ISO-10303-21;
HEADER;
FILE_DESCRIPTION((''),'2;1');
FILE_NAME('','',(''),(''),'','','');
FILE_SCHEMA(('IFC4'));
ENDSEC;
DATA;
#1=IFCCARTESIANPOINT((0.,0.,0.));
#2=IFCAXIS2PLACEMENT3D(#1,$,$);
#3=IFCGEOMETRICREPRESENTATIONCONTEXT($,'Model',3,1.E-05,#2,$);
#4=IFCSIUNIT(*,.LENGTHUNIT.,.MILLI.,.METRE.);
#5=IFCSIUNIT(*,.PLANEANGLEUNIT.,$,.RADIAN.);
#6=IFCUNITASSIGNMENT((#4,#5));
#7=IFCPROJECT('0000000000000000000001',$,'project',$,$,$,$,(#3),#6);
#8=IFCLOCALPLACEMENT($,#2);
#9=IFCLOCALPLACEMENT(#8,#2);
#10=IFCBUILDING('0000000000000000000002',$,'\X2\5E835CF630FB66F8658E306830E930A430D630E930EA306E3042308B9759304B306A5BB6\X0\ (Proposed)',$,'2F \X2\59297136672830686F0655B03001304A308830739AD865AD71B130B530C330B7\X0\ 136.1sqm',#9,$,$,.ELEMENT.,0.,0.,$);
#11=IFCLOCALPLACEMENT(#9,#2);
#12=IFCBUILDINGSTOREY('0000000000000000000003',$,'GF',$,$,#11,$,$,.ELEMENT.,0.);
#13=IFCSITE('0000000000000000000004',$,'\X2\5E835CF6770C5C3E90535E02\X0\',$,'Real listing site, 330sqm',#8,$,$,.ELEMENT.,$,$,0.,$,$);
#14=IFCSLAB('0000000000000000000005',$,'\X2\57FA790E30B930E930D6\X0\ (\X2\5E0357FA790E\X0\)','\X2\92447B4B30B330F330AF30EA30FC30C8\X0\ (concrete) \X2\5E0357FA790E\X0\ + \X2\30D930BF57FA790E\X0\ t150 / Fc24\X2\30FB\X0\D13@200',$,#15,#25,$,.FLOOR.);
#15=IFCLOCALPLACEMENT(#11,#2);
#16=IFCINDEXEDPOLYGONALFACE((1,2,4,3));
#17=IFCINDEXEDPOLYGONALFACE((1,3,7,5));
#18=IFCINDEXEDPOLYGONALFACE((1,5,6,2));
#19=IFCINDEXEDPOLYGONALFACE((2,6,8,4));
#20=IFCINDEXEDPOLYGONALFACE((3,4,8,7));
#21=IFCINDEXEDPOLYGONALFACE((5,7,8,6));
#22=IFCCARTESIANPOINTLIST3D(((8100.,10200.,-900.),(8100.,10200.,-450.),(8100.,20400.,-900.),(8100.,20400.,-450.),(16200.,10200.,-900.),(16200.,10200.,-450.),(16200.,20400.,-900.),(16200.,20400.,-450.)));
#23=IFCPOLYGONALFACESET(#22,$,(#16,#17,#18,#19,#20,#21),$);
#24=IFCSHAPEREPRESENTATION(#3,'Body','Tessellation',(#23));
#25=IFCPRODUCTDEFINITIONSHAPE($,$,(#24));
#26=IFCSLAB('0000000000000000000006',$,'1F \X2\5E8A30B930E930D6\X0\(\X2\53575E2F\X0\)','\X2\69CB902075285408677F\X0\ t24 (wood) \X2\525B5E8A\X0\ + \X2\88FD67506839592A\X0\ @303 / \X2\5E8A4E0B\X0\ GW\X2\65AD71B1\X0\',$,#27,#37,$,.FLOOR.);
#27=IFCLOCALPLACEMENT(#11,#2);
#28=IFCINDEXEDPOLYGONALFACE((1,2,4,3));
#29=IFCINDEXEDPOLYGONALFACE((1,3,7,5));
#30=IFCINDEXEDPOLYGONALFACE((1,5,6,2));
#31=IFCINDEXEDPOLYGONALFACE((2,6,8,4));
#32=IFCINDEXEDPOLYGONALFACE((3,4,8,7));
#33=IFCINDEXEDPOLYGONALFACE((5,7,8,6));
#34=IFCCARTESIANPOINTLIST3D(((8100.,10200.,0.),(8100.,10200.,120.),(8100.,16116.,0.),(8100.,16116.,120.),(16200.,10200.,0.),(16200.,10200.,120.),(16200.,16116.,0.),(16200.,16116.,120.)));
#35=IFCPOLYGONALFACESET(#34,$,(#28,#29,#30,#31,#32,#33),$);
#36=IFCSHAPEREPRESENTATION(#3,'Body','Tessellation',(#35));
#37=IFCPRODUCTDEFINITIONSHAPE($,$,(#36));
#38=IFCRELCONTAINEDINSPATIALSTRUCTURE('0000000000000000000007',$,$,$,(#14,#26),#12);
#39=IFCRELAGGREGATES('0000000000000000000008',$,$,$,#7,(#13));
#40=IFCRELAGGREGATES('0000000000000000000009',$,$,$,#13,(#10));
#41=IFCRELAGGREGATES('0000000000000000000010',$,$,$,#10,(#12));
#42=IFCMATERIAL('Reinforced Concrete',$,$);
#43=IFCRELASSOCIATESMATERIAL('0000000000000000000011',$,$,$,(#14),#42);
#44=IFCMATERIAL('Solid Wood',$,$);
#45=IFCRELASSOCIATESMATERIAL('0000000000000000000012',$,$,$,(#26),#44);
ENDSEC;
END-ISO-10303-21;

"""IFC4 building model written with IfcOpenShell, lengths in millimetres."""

from ifc_helpers import new_model, si_unit, frame, frame_2d, origin, place, context, project, spatial, rectangle, extrude, material, element, save


model = new_model("IFC4")

# Units and contexts
model_context = context("Model", 3, precision=1e-05, world=origin())
ifc_project = project(units=[si_unit("LENGTHUNIT", "METRE", prefix="MILLI"), si_unit("PLANEANGLEUNIT", "RADIAN")], contexts=[model_context])

# Site, building, storey
site_placement = place(None, origin())
site = spatial("IfcSite", under=ifc_project, at=site_placement, Name="広島県尾道市", ObjectType="Real listing site, 330sqm", CompositionType="ELEMENT", RefElevation=0.0)
building_placement = place(site_placement, origin())
building = spatial("IfcBuilding", under=site, at=building_placement, Name="広島・書斎とライブラリのある静かな家 (Proposed)", ObjectType="2F 天然木と漆喰、および高断熱サッシ 136.1sqm", CompositionType="ELEMENT", ElevationOfRefHeight=0.0, ElevationOfTerrain=0.0)
storey_placement = place(building_placement, origin())
storey = spatial("IfcBuildingStorey", under=building, at=storey_placement, Name="GF", CompositionType="ELEMENT", Elevation=0.0)

# Shared definitions
ifc_material_1 = material(Name="Solid Wood")

# Slabs
ifc_material_2 = material(Name="Reinforced Concrete")
slab_1_placement = place(storey_placement, frame((4050.0, 5100.0, -450.0)))
element("IfcSlab", 1, at=slab_1_placement, inside=storey, material=ifc_material_2, Name="基礎スラブ (布基礎)", Description="鉄筋コンクリート (concrete) 布基礎 + ベタ基礎 t150 / Fc24・D13@200", PredefinedType="FLOOR", context=model_context, shape_type="SweptSolid", body=[
    extrude(rectangle(XDim=8100.0, YDim=10200.0, at=frame_2d((4050.0, 5100.0))), frame((4050.0, 5100.0, -450.0)), (0.0, 0.0, 1.0), 450.0),
])
slab_2_placement = place(storey_placement, frame((4050.0, 5100.0, 0.0)))
element("IfcSlab", 2, at=slab_2_placement, inside=storey, material=ifc_material_1, Name="1F 床スラブ(南帯)", Description="構造用合板 t24 (wood) 剛床 + 製材根太 @303 / 床下 GW断熱", PredefinedType="FLOOR", context=model_context, shape_type="SweptSolid", body=[
    extrude(rectangle(XDim=8100.0, YDim=5916.0, at=frame_2d((4050.0, 2958.0))), frame((4050.0, 5100.0, 0.0)), (0.0, 0.0, 1.0), 120.0),
])

save(model, "model.ifc")
